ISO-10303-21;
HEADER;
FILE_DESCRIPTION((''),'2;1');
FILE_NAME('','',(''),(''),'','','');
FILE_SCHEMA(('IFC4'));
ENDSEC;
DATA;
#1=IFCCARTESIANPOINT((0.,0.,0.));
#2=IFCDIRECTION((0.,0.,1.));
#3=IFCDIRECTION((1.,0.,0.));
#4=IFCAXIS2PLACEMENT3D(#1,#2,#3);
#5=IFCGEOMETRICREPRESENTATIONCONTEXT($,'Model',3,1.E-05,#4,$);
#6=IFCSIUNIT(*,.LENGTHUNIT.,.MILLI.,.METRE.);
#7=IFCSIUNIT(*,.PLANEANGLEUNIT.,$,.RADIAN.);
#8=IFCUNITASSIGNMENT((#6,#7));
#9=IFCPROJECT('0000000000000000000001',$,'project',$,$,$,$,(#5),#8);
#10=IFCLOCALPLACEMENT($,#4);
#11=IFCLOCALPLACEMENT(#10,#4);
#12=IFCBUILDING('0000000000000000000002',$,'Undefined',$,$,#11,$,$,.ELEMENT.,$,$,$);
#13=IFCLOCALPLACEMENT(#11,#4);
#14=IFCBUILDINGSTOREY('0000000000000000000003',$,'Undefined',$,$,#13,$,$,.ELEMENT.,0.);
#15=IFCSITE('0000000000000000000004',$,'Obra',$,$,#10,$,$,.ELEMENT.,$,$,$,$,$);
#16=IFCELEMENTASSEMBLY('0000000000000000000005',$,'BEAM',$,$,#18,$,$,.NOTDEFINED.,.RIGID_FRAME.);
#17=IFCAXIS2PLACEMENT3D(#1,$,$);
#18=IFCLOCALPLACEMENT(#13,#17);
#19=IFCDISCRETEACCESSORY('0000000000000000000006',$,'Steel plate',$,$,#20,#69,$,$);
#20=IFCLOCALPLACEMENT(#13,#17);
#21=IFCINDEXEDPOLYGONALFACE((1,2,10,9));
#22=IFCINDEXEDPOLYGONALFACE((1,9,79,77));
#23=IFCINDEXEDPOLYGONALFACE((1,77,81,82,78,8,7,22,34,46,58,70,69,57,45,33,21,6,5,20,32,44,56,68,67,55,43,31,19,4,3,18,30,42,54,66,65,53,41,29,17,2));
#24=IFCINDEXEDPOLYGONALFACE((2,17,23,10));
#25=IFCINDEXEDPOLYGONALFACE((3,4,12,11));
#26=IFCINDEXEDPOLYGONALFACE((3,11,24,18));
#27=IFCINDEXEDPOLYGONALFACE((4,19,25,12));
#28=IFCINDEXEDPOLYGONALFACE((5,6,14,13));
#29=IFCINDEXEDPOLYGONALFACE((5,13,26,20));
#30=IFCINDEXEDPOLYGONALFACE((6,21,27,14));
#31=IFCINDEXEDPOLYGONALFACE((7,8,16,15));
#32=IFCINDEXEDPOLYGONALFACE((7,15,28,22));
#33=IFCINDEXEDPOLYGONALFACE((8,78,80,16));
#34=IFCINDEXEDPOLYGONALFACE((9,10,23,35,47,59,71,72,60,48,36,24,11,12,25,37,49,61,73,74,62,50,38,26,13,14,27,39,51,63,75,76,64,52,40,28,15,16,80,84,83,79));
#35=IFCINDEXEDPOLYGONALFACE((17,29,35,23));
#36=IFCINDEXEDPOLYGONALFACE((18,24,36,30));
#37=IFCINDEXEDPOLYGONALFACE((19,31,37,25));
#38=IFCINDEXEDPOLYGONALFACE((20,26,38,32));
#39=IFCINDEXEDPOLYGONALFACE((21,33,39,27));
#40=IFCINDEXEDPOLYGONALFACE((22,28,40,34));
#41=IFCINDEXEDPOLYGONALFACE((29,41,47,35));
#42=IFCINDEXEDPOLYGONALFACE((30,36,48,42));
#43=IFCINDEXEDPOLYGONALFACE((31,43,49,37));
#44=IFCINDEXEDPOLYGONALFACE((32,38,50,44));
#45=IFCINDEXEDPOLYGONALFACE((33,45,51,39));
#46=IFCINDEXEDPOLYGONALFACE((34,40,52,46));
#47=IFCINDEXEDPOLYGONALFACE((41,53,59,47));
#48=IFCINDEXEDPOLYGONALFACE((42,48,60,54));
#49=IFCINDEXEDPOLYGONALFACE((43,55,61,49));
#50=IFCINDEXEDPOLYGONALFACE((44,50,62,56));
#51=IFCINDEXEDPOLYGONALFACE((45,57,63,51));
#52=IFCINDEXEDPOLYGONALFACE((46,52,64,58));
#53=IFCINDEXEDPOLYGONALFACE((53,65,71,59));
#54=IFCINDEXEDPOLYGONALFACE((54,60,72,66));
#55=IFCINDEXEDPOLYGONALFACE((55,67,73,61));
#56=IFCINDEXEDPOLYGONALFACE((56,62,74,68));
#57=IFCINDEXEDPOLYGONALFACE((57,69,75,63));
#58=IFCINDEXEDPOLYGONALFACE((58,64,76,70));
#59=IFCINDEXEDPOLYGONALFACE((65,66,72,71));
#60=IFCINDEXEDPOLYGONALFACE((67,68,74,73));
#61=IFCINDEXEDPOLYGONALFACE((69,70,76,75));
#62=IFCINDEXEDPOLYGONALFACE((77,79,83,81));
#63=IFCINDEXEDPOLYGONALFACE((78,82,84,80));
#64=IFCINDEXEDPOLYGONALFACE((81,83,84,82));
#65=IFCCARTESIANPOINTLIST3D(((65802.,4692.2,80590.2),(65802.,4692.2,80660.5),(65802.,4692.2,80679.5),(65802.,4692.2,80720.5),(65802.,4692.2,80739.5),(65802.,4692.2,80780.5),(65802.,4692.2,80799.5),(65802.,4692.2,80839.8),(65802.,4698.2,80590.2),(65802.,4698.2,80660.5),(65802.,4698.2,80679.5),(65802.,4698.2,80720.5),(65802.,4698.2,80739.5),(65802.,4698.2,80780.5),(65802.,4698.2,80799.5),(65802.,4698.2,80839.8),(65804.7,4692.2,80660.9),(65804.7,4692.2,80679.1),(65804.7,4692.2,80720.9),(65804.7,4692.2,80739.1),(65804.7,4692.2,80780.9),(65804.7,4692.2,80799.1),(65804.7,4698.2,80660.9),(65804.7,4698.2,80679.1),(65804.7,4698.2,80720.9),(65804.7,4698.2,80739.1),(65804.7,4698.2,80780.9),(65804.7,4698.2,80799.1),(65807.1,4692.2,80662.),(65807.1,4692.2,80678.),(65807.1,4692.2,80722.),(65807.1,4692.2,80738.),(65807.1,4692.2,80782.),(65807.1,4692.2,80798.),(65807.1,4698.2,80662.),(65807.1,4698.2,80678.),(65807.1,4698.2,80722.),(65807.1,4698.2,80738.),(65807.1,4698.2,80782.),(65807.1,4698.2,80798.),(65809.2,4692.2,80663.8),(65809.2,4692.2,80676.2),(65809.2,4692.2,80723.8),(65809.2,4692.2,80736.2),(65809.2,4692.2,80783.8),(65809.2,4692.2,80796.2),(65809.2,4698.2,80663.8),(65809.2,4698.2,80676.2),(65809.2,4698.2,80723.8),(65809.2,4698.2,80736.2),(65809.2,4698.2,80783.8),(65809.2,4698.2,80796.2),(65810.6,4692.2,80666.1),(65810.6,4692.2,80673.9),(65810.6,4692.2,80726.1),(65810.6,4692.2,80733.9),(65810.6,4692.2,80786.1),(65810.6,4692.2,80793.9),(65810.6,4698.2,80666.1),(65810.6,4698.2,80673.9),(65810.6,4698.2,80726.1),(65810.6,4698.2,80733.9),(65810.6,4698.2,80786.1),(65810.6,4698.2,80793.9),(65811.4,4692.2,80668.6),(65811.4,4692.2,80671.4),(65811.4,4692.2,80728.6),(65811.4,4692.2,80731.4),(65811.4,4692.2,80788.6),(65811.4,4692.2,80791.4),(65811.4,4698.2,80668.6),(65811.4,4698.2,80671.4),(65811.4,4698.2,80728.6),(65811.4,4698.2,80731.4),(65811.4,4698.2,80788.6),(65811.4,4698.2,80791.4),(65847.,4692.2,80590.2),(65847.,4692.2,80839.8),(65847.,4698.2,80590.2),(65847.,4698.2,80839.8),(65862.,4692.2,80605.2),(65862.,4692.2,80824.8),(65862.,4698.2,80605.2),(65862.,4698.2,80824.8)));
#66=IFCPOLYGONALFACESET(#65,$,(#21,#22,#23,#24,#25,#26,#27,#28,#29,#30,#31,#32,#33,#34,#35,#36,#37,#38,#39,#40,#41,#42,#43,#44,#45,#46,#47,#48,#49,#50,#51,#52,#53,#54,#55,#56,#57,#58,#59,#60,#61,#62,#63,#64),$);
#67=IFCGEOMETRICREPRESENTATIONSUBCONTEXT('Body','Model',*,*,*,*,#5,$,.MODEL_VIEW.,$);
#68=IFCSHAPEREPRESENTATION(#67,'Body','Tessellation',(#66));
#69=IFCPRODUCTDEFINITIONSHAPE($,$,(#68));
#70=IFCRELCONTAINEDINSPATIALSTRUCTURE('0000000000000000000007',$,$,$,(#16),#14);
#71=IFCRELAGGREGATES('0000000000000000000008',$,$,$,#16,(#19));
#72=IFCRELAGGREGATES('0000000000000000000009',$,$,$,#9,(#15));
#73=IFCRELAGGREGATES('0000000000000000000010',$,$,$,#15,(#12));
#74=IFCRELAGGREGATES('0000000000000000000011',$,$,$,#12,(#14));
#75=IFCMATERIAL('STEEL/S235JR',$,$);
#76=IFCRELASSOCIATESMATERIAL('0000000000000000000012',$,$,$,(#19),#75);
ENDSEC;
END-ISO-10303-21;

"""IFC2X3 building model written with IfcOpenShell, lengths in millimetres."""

from ifc_helpers import new_model, si_unit, frame, origin_with_axes, origin_2d_with_axis, place, context, subcontext, project, spatial, polyline, circle, outline, extrude, source, transform, mapped, material, element, aggregate, save


model = new_model("IFC2X3")

# Units and contexts
model_context = context("Model", 3, precision=1e-05, world=origin_with_axes())
body_context = subcontext(model_context, "Body", "Model", "MODEL_VIEW")
ifc_project = project(units=[si_unit("LENGTHUNIT", "METRE", prefix="MILLI"), si_unit("PLANEANGLEUNIT", "RADIAN")], contexts=[model_context])

# Site, building, storey
site_placement = place(None, origin_with_axes())
site = spatial("IfcSite", under=ifc_project, at=site_placement, Name="Obra", CompositionType="ELEMENT")
building_placement = place(site_placement, origin_with_axes())
building = spatial("IfcBuilding", under=site, at=building_placement, Name="Undefined", CompositionType="ELEMENT")
storey_placement = place(building_placement, origin_with_axes())
storey = spatial("IfcBuildingStorey", under=building, at=storey_placement, Name="Undefined", CompositionType="ELEMENT", Elevation=0.0)

# Element assembly
assembly_1_placement = place(storey_placement, origin_with_axes())
assembly_1 = element("IfcElementAssembly", 1, at=assembly_1_placement, inside=storey, Name="BEAM", AssemblyPlace="NOTDEFINED", PredefinedType="RIGID_FRAME")
ifc_material = material(Name="STEEL/S235JR")

# Shared definitions
shared_shape_1 = source(origin_with_axes(), body_context, "Body", "SweptSolid", [
    extrude(circle(Radius=9.5, at=origin_2d_with_axis()), frame((0.0, -9.2, 0.0), z_axis=(0.0, 1.0, 0.0), x_axis=(1.0, 0.0, 0.0)), (0.0, 0.0, 1.0), 6.2),
])

# Discrete accessory, opening
discrete_accessory_1_placement = place(assembly_1_placement, frame((65802.0, 4695.2, 80590.2), z_axis=(0.0, -1.0, 0.0), x_axis=(1.0, 0.0, 0.0)))
discrete_accessory_1 = element("IfcDiscreteAccessory", 2, at=discrete_accessory_1_placement, material=ifc_material, Name="Steel plate", context=body_context, shape_type="SweptSolid", body=[
    extrude(outline(polyline([(0.0, 0.0), (45.0, 0.0), (60.0, 15.0), (60.0, 234.6), (45.0, 249.6), (0.0, 249.6), (0.0, 0.0)])), frame((0.0, 0.0, -3.0), z_axis=(0.0, 0.0, 1.0), x_axis=(1.0, 0.0, 0.0)), (0.0, 0.0, 1.0), 6.0),
])
opening_1_placement = place(assembly_1_placement, frame((65852.0, 4689.1, 80850.0), z_axis=(-1.0, 0.0, 0.0), x_axis=(0.0, 0.0, -1.0)))
element("IfcOpeningElement", 3, at=opening_1_placement, cuts=discrete_accessory_1, ObjectType="Opening", context=body_context, shape_type="MappedRepresentation", body=[
    mapped(shared_shape_1, transform((60.0, 0.0, 50.0))),
    mapped(shared_shape_1, transform((120.0, 0.0, 50.0))),
    mapped(shared_shape_1, transform((180.0, 0.0, 50.0))),
])
aggregate(assembly_1, [discrete_accessory_1])

save(model, "model.ifc")
